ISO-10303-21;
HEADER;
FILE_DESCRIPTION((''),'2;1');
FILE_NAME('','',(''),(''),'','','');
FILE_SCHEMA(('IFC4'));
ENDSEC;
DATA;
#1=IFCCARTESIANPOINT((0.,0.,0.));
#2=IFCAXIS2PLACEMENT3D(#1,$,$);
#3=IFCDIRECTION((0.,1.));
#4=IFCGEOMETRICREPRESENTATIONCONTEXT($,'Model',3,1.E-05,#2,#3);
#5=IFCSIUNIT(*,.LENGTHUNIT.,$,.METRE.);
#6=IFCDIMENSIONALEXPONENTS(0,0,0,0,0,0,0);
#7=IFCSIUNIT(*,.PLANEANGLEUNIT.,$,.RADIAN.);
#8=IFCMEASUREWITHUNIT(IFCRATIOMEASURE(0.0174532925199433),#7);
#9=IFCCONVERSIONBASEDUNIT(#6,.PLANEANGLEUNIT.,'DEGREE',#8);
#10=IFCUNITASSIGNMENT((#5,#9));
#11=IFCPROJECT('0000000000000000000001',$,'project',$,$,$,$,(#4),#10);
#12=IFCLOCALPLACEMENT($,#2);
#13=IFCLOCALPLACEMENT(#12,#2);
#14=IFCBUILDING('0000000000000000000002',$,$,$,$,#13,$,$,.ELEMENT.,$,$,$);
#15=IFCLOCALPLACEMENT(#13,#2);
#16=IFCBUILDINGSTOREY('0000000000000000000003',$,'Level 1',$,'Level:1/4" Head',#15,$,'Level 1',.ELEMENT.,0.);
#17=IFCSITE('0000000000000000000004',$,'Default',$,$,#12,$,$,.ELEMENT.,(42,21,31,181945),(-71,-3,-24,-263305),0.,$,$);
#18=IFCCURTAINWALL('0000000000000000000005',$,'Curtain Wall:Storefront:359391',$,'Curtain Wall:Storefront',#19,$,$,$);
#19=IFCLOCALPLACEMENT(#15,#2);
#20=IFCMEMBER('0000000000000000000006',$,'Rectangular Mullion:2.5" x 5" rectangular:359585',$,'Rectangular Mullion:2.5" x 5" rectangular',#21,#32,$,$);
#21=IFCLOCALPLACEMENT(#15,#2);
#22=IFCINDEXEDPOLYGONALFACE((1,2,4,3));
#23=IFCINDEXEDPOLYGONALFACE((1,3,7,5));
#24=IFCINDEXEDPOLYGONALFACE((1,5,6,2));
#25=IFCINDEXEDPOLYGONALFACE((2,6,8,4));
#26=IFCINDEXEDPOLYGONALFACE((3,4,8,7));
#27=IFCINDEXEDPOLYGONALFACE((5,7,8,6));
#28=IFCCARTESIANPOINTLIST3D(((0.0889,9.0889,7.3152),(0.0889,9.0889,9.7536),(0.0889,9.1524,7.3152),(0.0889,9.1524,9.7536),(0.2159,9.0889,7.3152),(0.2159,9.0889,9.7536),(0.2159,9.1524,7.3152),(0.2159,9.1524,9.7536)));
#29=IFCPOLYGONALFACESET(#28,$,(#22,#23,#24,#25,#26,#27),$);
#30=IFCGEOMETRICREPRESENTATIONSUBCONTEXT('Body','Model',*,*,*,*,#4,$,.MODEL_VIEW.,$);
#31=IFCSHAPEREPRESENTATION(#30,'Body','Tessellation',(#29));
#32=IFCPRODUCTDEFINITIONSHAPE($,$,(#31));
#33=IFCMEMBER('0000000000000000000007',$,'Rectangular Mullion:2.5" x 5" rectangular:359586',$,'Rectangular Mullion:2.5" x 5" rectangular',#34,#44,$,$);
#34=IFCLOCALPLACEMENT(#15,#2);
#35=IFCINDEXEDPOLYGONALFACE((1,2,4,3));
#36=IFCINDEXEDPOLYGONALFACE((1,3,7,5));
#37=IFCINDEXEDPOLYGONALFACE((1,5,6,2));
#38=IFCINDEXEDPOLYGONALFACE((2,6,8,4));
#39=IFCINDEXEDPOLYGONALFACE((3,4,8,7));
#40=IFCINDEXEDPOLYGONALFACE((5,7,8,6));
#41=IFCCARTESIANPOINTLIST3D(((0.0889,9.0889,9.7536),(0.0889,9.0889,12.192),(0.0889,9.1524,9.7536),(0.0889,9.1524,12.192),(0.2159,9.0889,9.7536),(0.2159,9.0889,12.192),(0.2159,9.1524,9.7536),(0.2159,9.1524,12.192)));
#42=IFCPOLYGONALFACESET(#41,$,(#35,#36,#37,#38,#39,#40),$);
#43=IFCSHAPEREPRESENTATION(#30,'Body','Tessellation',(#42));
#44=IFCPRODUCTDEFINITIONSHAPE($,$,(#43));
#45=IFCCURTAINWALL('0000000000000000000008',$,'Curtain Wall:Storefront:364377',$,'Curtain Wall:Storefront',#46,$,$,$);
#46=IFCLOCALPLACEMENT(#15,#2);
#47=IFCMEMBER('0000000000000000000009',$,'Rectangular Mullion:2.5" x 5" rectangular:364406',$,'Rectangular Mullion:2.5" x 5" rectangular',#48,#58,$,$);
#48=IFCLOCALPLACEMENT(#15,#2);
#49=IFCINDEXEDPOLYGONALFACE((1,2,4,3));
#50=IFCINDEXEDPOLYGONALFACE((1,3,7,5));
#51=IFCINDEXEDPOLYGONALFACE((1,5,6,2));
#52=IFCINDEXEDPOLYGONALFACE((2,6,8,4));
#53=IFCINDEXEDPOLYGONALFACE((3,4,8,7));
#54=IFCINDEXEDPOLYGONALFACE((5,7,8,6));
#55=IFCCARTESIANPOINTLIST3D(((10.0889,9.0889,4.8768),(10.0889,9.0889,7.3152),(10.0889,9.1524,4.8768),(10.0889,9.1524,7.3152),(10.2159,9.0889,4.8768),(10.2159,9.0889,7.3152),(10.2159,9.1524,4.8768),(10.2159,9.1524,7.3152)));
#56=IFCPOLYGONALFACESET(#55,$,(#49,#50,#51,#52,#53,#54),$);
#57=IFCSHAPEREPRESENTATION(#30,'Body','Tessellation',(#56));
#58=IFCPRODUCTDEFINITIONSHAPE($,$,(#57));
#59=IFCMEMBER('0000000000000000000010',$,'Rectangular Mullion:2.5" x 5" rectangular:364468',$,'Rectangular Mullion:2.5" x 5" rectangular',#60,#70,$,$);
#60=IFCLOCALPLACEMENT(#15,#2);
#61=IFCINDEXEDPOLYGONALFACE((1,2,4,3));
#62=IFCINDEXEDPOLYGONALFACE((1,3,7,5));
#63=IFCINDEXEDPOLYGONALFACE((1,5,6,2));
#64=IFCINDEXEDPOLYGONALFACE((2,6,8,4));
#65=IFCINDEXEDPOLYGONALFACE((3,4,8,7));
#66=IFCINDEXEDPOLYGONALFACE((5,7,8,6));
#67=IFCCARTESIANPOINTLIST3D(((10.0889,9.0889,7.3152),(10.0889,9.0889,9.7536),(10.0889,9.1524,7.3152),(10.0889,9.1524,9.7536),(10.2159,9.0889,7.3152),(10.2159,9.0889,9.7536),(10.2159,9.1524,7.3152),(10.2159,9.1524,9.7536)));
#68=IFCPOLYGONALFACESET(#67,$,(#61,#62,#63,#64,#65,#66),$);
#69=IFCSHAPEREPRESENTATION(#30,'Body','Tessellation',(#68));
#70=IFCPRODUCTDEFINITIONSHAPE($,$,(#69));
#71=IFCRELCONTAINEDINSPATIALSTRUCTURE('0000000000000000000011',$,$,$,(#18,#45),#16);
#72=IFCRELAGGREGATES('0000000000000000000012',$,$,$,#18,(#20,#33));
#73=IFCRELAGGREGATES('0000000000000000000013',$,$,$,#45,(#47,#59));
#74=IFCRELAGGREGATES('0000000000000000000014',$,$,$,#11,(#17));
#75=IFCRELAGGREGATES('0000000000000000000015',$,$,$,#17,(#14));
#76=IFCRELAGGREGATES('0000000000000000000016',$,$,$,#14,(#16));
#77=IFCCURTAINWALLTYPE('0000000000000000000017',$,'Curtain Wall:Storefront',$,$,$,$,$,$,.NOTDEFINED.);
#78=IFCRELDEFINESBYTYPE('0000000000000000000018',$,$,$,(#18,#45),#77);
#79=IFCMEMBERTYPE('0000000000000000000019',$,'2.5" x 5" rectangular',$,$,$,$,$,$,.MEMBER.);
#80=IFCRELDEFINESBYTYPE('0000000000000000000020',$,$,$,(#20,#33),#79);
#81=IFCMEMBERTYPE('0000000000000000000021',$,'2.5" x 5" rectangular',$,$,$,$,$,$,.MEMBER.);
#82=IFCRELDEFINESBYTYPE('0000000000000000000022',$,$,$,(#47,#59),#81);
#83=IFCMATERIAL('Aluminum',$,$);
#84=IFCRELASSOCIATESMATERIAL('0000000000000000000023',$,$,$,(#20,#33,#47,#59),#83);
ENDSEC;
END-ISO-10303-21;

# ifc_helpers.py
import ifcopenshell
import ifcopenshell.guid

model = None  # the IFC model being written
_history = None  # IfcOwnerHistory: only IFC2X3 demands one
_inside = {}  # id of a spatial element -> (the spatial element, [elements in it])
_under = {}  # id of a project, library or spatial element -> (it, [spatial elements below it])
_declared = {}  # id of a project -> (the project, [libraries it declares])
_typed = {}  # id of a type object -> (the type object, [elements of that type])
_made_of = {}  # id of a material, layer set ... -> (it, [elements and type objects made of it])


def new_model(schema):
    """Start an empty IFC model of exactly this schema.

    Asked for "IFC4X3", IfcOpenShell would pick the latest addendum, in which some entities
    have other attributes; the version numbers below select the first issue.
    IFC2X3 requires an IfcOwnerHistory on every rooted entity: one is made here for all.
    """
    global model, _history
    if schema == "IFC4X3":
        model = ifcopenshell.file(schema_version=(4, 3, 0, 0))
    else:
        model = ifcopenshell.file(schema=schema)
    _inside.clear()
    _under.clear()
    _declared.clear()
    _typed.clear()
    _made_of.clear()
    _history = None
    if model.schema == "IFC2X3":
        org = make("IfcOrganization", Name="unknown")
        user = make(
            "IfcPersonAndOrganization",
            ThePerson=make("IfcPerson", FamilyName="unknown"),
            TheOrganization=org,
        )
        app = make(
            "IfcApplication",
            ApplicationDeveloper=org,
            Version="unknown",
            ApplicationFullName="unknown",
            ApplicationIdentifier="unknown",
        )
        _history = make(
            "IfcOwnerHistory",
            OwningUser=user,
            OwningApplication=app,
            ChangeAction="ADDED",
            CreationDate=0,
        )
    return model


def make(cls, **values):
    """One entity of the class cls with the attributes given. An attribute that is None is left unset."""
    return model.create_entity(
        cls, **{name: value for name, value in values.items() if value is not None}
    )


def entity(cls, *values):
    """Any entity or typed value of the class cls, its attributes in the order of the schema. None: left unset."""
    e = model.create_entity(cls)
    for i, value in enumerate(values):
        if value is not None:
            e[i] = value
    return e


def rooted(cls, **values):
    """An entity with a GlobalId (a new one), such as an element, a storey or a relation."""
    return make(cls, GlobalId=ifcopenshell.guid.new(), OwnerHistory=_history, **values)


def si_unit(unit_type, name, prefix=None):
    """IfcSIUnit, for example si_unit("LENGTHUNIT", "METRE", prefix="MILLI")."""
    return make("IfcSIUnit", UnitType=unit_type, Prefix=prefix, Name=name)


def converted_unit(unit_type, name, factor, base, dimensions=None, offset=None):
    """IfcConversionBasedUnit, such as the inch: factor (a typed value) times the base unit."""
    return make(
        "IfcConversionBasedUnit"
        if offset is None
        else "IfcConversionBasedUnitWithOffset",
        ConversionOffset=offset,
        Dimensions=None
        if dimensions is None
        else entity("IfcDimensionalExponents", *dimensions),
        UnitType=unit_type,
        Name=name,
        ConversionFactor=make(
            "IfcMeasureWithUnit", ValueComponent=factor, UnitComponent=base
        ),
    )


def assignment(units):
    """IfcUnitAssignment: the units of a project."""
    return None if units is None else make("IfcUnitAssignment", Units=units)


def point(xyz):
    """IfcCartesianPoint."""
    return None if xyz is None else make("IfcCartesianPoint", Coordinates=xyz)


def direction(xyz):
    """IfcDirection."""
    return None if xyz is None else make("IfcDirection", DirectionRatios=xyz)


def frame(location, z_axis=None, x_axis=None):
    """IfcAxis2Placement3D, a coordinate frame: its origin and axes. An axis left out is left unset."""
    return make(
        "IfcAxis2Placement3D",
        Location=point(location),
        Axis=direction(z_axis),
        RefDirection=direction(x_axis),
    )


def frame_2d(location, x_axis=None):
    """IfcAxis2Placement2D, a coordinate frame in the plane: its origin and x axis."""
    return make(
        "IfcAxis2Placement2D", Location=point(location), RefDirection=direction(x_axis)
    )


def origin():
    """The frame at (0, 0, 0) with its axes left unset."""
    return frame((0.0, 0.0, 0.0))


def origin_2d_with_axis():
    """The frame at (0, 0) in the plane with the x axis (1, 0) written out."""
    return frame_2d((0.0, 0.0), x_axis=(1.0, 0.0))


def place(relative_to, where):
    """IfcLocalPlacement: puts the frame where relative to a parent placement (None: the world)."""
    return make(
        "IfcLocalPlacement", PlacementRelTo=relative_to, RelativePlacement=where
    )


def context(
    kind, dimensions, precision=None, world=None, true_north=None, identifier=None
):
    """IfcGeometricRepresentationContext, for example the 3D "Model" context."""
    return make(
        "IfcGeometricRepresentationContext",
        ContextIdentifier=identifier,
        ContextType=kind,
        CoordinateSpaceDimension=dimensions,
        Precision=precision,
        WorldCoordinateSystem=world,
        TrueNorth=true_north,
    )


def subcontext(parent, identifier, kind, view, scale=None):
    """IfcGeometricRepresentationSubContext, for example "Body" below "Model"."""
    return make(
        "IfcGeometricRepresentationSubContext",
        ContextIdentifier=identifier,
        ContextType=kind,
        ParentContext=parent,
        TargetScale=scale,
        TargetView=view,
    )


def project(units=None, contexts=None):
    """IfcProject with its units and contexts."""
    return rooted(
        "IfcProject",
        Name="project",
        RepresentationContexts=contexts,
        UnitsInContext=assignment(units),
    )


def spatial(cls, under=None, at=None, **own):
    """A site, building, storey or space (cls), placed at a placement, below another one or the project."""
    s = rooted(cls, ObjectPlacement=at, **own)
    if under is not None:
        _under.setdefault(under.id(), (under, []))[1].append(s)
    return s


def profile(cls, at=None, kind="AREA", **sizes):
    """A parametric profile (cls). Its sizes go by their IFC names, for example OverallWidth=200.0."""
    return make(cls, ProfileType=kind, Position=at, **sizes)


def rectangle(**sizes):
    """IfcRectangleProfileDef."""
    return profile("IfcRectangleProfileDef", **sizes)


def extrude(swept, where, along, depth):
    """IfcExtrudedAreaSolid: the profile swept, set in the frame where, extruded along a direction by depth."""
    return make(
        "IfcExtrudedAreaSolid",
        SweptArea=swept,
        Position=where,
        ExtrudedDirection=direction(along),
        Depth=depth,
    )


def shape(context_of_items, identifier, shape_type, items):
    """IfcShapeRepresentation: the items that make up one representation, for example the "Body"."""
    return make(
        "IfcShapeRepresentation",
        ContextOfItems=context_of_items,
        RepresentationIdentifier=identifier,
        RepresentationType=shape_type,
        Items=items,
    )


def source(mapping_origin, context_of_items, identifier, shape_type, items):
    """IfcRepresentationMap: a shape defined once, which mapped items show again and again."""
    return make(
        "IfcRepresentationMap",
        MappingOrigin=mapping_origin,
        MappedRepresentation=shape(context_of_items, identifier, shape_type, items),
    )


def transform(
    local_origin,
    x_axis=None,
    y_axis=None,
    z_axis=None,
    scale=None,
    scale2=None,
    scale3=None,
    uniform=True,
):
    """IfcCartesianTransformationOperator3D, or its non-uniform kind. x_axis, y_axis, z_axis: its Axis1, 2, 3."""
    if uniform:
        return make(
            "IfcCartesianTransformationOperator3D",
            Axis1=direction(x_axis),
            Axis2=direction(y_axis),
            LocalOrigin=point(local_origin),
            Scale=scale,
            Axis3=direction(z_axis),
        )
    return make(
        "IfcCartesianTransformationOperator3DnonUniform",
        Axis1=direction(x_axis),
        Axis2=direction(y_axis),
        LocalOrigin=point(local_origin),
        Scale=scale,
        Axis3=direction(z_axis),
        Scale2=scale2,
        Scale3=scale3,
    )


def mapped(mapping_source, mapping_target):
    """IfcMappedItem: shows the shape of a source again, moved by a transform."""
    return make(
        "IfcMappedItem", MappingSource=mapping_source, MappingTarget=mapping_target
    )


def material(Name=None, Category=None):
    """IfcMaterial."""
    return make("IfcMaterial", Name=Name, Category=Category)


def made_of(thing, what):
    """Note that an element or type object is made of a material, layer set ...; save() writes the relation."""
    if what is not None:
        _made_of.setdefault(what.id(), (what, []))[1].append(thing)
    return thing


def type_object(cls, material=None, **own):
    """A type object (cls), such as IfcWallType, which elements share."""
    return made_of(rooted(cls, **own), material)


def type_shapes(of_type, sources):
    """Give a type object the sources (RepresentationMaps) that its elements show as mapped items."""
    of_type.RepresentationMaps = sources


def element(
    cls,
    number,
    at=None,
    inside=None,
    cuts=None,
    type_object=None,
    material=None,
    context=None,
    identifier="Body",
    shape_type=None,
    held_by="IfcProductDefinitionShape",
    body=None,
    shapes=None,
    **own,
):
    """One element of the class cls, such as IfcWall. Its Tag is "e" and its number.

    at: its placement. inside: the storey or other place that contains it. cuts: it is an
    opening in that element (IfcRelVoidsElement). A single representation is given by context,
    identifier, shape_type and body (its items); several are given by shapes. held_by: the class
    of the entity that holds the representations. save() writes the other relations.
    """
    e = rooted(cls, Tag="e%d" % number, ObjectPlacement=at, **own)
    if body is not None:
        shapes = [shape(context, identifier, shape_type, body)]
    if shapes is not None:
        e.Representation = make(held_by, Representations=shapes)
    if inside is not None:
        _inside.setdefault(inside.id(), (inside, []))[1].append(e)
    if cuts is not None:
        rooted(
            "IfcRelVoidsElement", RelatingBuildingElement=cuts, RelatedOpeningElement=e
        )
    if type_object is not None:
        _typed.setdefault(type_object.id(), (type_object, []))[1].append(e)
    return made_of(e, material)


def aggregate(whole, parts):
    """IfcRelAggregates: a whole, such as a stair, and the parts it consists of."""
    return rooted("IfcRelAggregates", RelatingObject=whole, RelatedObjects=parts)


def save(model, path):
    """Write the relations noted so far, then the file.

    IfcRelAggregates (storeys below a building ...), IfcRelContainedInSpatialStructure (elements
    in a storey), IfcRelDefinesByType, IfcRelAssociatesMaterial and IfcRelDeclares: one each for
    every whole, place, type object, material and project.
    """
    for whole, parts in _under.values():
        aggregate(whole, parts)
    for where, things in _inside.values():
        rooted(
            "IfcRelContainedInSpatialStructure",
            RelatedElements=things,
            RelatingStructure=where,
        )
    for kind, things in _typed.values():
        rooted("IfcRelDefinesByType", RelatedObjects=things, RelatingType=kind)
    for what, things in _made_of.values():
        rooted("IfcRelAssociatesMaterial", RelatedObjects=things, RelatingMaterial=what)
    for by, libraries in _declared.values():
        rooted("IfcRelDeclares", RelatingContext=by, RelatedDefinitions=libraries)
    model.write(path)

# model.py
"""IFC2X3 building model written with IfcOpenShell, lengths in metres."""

from ifc_helpers import new_model, entity, si_unit, converted_unit, direction, frame, origin, origin_2d_with_axis, place, context, subcontext, project, spatial, rectangle, extrude, source, transform, mapped, material, type_object, type_shapes, element, aggregate, save


model = new_model("IFC2X3")

# Units and contexts
model_context = context("Model", 3, precision=1e-05, world=origin(), true_north=direction((0.0, 1.0)))
body_context = subcontext(model_context, "Body", "Model", "MODEL_VIEW")
ifc_project = project(units=[si_unit("LENGTHUNIT", "METRE"), converted_unit("PLANEANGLEUNIT", "DEGREE", entity("IfcRatioMeasure", 0.0174532925199433), si_unit("PLANEANGLEUNIT", "RADIAN"), dimensions=[0, 0, 0, 0, 0, 0, 0])], contexts=[model_context])

# Site, building, storey
site_placement = place(None, origin())
site = spatial("IfcSite", under=ifc_project, at=site_placement, Name="Default", CompositionType="ELEMENT", RefLatitude=(42, 21, 31, 181945), RefLongitude=(-71, -3, -24, -263305), RefElevation=0.0)
building_placement = place(site_placement, origin())
building = spatial("IfcBuilding", under=site, at=building_placement, CompositionType="ELEMENT")
storey_placement = place(building_placement, origin())
storey = spatial("IfcBuildingStorey", under=building, at=storey_placement, Name="Level 1", ObjectType="Level:1/4\" Head", LongName="Level 1", CompositionType="ELEMENT", Elevation=0.0)

# Curtain walls, members
curtain_wall_type = type_object("IfcCurtainWallType", Name="Curtain Wall:Storefront", PredefinedType="NOTDEFINED")
curtain_wall_1_placement = place(storey_placement, origin())
curtain_wall_1 = element("IfcCurtainWall", 1, at=curtain_wall_1_placement, inside=storey, type_object=curtain_wall_type, Name="Curtain Wall:Storefront:359391", ObjectType="Curtain Wall:Storefront")
ifc_material = material(Name="Aluminum")
member_type_1 = type_object("IfcMemberType", Name="2.5\" x 5\" rectangular", PredefinedType="MEMBER")
shared_shape_1 = source(origin(), body_context, "Body", "SweptSolid", [
    extrude(rectangle(XDim=0.127, YDim=0.0635, at=origin_2d_with_axis()), frame((-0.0318, 0.0, -2.4384), z_axis=(0.0, 0.0, 1.0), x_axis=(0.0, -1.0, 0.0)), (0.0, 0.0, 1.0), 2.4384),
])
type_shapes(member_type_1, [shared_shape_1])
member_1_placement = place(storey_placement, frame((0.1524, 9.1524, 7.3152), z_axis=(0.0, 0.0, -1.0), x_axis=(0.0, 1.0, 0.0)))
member_1 = element("IfcMember", 2, at=member_1_placement, type_object=member_type_1, material=ifc_material, Name="Rectangular Mullion:2.5\" x 5\" rectangular:359585", ObjectType="Rectangular Mullion:2.5\" x 5\" rectangular", context=body_context, shape_type="MappedRepresentation", body=[
    mapped(shared_shape_1, transform((0.0, 0.0, 0.0), scale=1.0)),
])
member_2_placement = place(storey_placement, frame((0.1524, 9.1524, 9.7536), z_axis=(0.0, 0.0, -1.0), x_axis=(0.0, 1.0, 0.0)))
member_2 = element("IfcMember", 3, at=member_2_placement, type_object=member_type_1, material=ifc_material, Name="Rectangular Mullion:2.5\" x 5\" rectangular:359586", ObjectType="Rectangular Mullion:2.5\" x 5\" rectangular", context=body_context, shape_type="MappedRepresentation", body=[
    mapped(shared_shape_1, transform((0.0, 0.0, 0.0), scale=1.0)),
])
aggregate(curtain_wall_1, [member_1, member_2])
curtain_wall_2_placement = place(storey_placement, origin())
curtain_wall_2 = element("IfcCurtainWall", 4, at=curtain_wall_2_placement, inside=storey, type_object=curtain_wall_type, Name="Curtain Wall:Storefront:364377", ObjectType="Curtain Wall:Storefront")
member_type_2 = type_object("IfcMemberType", Name="2.5\" x 5\" rectangular", PredefinedType="MEMBER")
shared_shape_2 = source(origin(), body_context, "Body", "SweptSolid", [
    extrude(rectangle(XDim=0.127, YDim=0.0635, at=origin_2d_with_axis()), frame((-0.0318, 0.0, -2.4384), z_axis=(0.0, 0.0, 1.0), x_axis=(0.0, -1.0, 0.0)), (0.0, 0.0, 1.0), 2.4384),
])
type_shapes(member_type_2, [shared_shape_2])
member_3_placement = place(storey_placement, frame((10.1524, 9.1524, 4.8768), z_axis=(0.0, 0.0, -1.0), x_axis=(0.0, 1.0, 0.0)))
member_3 = element("IfcMember", 5, at=member_3_placement, type_object=member_type_2, material=ifc_material, Name="Rectangular Mullion:2.5\" x 5\" rectangular:364406", ObjectType="Rectangular Mullion:2.5\" x 5\" rectangular", context=body_context, shape_type="MappedRepresentation", body=[
    mapped(shared_shape_2, transform((0.0, 0.0, 0.0), scale=1.0)),
])
member_4_placement = place(storey_placement, frame((10.1524, 9.1524, 7.3152), z_axis=(0.0, 0.0, -1.0), x_axis=(0.0, 1.0, 0.0)))
member_4 = element("IfcMember", 6, at=member_4_placement, type_object=member_type_2, material=ifc_material, Name="Rectangular Mullion:2.5\" x 5\" rectangular:364468", ObjectType="Rectangular Mullion:2.5\" x 5\" rectangular", context=body_context, shape_type="MappedRepresentation", body=[
    mapped(shared_shape_2, transform((0.0, 0.0, 0.0), scale=1.0)),
])
aggregate(curtain_wall_2, [member_3, member_4])

save(model, "model.ifc")
